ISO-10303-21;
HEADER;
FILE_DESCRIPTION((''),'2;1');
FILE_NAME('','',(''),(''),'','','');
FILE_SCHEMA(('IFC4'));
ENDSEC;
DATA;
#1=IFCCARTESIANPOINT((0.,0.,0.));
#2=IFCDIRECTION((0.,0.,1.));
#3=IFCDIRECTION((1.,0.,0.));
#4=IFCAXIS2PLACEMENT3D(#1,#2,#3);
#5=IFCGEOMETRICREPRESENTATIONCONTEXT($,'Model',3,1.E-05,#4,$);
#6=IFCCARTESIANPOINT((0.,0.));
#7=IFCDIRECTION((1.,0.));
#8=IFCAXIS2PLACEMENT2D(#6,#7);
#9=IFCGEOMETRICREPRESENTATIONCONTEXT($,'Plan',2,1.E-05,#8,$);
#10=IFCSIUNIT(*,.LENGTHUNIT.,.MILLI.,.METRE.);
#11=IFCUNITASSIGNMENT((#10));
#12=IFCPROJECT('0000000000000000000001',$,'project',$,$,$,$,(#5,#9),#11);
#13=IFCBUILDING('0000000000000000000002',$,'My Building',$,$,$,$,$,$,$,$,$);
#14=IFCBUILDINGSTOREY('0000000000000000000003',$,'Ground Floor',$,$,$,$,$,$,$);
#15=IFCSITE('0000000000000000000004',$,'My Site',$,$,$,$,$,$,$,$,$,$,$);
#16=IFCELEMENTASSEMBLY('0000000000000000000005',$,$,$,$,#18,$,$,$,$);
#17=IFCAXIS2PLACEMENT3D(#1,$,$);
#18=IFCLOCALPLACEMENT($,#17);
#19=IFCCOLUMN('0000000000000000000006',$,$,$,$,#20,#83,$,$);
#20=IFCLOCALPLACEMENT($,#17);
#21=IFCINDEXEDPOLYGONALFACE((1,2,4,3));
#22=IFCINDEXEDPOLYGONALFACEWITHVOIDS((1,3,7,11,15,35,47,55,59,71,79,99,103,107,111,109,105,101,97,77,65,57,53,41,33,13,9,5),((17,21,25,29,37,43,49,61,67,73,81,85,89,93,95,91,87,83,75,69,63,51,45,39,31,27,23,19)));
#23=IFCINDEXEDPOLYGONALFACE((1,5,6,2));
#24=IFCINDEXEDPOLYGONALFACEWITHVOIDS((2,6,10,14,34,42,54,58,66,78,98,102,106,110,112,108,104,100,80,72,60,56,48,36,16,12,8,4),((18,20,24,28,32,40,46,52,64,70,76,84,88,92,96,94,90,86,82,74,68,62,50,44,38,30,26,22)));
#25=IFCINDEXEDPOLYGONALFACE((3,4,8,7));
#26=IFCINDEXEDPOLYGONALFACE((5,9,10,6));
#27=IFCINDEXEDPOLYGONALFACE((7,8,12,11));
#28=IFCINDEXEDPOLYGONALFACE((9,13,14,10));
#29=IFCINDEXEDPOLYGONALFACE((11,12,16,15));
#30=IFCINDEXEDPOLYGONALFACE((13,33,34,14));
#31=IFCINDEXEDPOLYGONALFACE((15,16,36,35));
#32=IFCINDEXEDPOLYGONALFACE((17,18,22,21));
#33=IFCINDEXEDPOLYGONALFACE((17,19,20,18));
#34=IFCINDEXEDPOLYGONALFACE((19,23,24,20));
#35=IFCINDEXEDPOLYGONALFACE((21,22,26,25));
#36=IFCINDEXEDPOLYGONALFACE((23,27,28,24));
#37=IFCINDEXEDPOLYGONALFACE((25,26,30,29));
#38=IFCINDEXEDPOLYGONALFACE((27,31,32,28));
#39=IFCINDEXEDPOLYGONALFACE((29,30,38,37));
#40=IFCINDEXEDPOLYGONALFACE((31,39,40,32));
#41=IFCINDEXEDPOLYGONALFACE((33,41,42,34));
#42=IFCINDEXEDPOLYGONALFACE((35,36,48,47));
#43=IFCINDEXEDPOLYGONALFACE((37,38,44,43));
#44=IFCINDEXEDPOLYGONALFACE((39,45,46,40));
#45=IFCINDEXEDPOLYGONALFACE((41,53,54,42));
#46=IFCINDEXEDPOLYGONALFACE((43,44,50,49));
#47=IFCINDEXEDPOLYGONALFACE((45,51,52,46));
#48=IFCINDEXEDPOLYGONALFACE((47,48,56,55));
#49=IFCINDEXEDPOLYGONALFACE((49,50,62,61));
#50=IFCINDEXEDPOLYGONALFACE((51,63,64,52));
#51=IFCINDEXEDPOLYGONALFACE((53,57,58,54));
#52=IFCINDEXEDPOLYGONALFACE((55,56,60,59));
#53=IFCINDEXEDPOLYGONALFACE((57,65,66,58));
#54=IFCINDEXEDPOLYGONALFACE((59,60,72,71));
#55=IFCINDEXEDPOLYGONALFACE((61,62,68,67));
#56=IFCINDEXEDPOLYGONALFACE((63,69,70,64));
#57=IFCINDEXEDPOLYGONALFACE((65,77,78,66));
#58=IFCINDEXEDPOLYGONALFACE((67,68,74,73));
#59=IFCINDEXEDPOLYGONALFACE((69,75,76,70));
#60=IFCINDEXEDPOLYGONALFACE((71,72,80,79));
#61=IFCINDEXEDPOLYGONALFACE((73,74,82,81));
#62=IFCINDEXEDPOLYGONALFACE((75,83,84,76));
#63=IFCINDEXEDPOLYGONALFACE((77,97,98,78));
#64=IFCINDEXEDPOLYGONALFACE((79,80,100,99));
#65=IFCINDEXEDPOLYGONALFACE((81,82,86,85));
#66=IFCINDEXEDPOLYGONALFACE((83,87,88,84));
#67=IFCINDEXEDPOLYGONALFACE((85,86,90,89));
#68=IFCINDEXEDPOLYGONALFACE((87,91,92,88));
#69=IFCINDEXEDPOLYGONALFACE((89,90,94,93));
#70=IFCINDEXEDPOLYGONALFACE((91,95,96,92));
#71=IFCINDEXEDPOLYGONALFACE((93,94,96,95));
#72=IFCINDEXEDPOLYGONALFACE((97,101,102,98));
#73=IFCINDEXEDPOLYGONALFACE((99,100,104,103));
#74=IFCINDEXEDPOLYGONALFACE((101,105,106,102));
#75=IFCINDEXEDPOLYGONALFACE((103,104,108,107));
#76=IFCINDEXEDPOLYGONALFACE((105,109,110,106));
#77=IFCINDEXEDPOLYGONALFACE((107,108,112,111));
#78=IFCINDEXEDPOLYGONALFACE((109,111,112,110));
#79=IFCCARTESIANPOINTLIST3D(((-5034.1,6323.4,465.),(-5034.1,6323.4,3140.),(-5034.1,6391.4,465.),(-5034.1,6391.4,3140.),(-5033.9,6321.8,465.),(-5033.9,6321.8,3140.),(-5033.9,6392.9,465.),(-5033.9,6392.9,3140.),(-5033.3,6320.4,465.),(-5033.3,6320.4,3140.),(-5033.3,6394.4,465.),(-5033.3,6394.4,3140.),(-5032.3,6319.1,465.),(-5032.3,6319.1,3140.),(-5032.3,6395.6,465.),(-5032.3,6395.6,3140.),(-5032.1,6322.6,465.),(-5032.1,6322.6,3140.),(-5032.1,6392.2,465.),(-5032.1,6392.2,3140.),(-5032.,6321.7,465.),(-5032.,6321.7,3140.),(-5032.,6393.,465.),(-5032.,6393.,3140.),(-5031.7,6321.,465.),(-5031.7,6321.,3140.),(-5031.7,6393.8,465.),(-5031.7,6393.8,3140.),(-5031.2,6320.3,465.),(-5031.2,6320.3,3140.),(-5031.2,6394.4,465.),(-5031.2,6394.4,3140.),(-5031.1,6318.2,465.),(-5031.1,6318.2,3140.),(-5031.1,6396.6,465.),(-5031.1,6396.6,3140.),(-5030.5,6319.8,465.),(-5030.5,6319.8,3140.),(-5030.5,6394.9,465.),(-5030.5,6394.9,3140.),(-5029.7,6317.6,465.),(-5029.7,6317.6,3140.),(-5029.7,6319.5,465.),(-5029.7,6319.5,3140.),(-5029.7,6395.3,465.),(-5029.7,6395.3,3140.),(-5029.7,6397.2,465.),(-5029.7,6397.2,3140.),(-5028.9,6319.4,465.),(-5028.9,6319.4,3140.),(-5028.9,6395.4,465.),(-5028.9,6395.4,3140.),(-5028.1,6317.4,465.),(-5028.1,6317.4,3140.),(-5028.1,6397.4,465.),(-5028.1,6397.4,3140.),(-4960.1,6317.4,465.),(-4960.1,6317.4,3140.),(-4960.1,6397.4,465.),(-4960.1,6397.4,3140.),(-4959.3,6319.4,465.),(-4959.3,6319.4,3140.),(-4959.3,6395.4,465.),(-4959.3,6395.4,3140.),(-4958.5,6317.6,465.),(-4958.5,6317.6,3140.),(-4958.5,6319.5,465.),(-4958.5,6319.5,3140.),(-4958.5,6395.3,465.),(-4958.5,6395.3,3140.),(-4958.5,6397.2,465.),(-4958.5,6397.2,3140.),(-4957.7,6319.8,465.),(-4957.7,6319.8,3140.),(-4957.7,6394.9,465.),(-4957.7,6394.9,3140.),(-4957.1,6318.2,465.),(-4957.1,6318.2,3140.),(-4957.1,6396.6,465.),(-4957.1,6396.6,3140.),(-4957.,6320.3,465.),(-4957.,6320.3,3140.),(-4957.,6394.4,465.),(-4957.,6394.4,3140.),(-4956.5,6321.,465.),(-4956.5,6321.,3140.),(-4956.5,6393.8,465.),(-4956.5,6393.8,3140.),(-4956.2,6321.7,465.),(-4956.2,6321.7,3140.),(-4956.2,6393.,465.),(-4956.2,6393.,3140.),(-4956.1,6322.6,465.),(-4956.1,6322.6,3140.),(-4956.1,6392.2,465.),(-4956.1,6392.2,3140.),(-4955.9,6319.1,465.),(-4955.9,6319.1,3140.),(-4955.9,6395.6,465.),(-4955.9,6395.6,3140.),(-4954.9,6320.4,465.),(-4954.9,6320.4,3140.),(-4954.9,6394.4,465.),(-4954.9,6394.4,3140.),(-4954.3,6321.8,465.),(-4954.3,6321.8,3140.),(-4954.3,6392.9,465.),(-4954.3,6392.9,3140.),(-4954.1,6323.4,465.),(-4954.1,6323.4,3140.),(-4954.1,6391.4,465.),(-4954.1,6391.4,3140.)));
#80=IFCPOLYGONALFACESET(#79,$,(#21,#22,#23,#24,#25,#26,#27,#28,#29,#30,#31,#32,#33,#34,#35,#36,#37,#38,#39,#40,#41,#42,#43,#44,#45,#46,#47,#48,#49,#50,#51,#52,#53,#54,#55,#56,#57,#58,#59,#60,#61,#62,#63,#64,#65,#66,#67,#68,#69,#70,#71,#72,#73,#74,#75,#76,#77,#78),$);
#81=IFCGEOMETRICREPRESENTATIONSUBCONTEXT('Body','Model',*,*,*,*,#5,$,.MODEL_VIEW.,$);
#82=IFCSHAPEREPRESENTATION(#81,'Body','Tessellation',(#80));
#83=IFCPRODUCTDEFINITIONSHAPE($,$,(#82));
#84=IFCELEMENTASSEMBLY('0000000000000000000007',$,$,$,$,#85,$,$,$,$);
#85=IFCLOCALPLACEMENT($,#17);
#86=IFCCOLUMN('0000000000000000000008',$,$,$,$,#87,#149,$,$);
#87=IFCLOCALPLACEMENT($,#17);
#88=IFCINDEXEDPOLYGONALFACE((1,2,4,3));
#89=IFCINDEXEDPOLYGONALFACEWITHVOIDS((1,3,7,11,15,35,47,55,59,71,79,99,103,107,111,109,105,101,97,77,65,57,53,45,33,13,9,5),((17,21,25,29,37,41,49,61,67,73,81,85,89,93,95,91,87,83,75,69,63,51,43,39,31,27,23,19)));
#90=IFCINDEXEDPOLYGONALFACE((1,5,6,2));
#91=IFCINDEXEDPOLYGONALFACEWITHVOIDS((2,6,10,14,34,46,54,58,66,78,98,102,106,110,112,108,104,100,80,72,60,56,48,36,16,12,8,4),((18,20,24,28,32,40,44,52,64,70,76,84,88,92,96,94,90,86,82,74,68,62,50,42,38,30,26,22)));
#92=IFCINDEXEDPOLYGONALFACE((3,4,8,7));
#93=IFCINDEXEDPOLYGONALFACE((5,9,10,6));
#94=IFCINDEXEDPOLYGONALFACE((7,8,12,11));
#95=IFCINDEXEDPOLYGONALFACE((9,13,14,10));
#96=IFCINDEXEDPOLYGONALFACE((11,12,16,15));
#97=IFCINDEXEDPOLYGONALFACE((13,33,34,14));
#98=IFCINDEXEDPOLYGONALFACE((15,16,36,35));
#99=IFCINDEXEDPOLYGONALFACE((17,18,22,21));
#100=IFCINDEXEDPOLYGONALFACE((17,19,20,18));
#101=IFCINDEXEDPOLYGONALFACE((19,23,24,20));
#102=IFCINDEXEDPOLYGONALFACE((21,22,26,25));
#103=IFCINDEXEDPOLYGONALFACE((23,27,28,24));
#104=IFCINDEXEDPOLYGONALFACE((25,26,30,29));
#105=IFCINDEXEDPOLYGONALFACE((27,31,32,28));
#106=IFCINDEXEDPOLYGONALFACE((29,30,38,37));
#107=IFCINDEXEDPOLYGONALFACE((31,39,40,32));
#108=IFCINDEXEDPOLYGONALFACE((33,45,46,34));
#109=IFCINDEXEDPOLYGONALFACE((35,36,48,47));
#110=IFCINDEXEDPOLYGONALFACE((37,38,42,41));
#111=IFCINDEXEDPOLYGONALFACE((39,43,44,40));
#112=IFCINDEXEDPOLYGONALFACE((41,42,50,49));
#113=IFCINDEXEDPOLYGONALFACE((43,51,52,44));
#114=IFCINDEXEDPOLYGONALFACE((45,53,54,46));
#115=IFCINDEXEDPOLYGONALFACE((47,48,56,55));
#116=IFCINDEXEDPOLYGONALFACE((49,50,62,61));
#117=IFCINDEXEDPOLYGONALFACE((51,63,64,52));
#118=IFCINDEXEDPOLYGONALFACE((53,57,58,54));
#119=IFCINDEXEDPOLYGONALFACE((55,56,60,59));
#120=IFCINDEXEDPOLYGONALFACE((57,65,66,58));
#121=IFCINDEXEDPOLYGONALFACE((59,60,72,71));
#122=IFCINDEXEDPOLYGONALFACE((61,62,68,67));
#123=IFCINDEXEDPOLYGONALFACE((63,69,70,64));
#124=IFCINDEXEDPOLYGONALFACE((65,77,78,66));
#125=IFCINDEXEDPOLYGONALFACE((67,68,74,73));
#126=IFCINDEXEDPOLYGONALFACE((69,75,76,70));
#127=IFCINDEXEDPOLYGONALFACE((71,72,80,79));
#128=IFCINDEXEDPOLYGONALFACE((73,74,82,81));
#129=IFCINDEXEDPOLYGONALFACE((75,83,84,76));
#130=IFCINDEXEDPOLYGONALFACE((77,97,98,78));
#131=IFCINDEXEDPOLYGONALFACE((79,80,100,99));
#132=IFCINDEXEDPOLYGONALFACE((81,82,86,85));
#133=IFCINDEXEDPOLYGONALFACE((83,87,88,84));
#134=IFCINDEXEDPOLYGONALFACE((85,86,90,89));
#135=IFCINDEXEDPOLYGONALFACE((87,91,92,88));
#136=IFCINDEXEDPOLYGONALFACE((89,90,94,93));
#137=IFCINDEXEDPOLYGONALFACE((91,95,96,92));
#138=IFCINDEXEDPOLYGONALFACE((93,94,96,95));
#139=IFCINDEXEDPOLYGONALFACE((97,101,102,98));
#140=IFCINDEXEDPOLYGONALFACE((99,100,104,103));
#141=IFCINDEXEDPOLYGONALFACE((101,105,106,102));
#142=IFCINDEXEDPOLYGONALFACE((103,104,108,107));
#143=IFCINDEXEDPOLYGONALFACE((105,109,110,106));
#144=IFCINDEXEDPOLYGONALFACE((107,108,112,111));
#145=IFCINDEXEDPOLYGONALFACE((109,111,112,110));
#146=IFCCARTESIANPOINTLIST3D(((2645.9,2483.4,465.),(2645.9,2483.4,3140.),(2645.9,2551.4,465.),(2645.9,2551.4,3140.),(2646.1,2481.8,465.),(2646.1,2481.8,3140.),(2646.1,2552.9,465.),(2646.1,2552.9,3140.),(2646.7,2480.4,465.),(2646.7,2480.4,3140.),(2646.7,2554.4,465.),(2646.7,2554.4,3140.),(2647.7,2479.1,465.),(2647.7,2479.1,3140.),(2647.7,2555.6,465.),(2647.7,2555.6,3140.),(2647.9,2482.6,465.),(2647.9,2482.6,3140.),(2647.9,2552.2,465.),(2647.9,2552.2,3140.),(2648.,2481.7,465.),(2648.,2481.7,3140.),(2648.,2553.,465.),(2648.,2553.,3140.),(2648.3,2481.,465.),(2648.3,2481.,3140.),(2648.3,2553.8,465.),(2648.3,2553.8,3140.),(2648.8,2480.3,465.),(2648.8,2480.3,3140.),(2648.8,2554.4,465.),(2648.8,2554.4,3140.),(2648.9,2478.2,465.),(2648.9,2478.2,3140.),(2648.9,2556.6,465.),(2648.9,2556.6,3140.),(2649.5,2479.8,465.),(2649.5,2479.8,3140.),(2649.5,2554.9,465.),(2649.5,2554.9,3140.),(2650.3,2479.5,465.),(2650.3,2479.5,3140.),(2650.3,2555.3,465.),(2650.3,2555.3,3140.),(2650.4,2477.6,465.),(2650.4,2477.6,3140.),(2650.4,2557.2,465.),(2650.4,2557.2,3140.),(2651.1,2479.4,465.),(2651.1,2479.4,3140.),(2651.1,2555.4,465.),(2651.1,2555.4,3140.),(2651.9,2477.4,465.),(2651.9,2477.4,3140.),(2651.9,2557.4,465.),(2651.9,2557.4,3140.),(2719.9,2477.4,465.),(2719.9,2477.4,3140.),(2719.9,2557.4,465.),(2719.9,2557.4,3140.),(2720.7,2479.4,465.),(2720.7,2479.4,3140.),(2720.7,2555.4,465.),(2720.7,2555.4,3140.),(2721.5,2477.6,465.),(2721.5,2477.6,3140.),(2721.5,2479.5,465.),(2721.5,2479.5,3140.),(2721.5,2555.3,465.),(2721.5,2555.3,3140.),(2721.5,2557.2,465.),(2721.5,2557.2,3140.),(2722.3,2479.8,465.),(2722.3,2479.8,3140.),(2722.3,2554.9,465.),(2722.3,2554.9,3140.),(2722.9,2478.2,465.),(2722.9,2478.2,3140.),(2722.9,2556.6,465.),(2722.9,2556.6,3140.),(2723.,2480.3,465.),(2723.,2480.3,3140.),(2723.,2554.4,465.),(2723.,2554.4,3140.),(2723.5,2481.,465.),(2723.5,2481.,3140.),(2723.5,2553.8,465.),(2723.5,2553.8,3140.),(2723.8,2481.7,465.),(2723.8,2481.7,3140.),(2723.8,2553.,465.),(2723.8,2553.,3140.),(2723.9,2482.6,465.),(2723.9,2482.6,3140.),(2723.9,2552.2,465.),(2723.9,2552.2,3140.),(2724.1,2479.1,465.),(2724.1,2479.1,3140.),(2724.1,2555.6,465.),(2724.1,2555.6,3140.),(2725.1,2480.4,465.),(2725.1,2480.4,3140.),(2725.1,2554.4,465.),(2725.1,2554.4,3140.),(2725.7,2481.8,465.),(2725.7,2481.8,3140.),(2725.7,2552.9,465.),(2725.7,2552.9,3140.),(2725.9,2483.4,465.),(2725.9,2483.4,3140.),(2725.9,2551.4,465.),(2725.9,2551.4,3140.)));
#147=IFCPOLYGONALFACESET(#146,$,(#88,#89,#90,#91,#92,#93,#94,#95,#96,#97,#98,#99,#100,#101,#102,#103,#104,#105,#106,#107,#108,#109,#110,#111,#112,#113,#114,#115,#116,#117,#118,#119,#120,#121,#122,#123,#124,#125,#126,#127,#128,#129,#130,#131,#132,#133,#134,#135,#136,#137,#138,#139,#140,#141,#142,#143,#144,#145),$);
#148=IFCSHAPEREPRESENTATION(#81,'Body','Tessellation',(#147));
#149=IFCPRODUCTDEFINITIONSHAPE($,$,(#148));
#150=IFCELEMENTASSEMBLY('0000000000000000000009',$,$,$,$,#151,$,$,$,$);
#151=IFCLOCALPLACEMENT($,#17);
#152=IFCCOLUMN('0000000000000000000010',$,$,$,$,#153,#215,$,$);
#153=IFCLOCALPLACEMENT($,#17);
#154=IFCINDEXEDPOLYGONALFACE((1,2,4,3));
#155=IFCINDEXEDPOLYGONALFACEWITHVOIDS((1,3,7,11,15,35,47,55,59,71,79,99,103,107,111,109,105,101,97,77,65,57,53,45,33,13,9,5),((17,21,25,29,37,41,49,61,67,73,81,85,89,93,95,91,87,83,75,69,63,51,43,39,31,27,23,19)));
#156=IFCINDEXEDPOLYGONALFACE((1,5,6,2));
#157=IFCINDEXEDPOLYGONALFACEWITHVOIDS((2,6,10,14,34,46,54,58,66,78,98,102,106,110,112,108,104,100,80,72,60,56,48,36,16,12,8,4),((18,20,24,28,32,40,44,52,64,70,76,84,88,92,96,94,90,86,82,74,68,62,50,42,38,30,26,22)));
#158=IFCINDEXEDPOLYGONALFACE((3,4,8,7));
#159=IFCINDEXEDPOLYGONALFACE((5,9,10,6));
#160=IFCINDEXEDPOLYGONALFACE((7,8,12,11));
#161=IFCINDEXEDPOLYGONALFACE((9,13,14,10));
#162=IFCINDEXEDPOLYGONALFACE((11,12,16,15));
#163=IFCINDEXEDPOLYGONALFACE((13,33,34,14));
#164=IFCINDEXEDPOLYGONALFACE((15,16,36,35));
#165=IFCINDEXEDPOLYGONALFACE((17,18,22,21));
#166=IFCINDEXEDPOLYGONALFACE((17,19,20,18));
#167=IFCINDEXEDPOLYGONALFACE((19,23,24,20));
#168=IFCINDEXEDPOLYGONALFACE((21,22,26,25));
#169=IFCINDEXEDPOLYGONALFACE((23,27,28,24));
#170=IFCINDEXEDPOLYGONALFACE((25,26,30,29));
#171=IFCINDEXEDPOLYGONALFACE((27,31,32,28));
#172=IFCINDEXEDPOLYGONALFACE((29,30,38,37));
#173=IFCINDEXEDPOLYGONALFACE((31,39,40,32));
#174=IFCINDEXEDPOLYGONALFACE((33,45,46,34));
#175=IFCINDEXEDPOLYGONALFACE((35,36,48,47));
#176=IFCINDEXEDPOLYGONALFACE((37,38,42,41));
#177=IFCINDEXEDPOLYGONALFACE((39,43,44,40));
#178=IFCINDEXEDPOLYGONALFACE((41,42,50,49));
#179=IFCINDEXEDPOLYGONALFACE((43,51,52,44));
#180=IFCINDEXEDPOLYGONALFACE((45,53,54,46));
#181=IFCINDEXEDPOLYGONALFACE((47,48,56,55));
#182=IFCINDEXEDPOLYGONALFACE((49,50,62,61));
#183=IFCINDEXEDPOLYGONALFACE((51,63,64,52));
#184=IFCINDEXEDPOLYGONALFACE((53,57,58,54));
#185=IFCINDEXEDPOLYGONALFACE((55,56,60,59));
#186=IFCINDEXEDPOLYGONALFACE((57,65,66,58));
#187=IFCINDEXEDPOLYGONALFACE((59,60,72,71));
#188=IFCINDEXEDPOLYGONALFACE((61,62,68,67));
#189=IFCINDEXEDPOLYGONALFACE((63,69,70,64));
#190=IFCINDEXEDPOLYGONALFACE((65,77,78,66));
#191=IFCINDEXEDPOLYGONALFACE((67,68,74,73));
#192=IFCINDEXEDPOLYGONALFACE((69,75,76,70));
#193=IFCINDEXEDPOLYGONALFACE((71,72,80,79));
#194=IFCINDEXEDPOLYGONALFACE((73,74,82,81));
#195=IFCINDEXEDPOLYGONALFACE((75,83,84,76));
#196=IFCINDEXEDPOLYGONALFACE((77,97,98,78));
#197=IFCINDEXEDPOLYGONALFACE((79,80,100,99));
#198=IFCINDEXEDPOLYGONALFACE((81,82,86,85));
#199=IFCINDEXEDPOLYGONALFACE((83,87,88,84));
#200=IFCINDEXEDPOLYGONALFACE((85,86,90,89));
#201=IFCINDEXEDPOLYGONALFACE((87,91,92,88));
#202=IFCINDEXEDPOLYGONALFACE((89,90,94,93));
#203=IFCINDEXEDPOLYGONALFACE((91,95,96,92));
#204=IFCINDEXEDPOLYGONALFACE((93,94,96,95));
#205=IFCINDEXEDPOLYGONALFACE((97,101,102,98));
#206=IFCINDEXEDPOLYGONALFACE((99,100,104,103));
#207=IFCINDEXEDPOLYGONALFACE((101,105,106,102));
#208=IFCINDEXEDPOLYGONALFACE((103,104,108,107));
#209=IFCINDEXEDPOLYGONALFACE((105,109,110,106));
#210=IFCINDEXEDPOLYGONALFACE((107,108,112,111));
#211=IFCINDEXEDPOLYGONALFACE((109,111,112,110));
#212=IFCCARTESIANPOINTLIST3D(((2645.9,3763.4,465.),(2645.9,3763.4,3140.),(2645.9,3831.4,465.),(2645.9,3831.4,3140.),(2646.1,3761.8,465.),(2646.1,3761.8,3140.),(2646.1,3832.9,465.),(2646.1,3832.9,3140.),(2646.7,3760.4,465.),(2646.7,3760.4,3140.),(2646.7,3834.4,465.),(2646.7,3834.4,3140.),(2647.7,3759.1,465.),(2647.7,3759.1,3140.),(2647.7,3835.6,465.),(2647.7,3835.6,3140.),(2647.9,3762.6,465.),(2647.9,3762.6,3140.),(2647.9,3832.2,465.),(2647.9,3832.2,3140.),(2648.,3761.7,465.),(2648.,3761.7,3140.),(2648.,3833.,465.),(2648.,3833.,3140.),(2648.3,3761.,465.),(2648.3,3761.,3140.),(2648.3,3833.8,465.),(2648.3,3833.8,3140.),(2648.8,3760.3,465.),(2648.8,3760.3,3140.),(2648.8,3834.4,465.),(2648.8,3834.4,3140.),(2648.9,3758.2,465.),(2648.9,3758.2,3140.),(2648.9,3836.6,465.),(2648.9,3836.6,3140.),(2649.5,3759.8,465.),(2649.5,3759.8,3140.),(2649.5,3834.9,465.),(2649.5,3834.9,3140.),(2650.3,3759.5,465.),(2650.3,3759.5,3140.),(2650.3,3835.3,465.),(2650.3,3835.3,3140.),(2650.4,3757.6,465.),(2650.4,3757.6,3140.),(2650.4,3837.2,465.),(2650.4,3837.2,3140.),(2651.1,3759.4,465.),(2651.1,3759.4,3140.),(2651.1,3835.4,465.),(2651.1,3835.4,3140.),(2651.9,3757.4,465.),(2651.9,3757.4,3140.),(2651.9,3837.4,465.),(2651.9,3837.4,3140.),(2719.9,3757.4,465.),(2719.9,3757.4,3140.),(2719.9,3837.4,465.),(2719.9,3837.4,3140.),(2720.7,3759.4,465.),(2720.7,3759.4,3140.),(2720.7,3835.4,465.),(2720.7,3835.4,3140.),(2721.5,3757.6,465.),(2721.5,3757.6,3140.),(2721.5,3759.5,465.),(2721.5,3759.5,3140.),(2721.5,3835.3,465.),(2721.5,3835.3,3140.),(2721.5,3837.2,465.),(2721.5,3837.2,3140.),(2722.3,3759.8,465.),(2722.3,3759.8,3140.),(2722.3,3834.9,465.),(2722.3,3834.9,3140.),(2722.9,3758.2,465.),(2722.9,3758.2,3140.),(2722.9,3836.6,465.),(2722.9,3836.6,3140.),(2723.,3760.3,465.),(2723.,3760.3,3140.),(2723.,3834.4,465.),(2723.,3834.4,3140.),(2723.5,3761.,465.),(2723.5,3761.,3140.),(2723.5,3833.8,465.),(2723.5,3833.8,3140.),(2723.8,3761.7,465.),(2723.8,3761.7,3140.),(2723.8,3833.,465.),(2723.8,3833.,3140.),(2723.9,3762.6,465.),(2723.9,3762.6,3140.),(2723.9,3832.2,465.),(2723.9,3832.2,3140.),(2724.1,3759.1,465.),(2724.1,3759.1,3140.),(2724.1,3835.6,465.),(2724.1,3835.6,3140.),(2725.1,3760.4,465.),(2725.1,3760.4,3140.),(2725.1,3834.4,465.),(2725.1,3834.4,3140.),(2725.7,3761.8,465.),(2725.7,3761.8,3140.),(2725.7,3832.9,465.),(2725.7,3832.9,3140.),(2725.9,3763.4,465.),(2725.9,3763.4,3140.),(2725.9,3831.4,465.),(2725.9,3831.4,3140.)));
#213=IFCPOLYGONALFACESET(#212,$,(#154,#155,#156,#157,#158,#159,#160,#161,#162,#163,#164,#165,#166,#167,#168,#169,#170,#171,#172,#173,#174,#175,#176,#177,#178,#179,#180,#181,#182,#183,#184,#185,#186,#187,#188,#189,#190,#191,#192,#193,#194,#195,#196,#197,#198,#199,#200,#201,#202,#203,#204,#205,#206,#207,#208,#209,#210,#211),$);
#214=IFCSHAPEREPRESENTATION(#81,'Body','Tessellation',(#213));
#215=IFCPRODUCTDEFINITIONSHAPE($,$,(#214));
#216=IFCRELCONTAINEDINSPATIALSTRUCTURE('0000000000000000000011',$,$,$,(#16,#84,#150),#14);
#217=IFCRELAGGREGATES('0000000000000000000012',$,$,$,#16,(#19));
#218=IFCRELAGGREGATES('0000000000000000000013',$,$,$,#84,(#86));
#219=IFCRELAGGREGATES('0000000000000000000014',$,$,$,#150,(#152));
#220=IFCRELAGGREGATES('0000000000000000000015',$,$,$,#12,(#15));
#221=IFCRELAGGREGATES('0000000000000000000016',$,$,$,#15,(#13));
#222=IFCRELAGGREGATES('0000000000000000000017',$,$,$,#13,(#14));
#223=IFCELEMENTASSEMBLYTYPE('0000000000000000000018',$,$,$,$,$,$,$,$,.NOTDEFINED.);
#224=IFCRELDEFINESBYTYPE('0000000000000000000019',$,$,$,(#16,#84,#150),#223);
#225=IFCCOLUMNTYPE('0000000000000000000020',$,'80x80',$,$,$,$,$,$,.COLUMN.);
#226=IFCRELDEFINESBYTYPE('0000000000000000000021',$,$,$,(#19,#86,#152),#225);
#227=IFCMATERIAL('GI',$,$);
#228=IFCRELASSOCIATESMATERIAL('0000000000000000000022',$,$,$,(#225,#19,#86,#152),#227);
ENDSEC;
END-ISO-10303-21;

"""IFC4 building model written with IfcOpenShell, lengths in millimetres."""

from ifc_helpers import new_model, si_unit, frame, origin_with_axes, origin_2d_with_axis, place, context, subcontext, project, spatial, hollow_rectangle, extrude, material, material_profile, profile_set, profile_usage, type_object, element, aggregate, save


model = new_model("IFC4")

# Units and contexts
model_context = context("Model", 3, precision=1e-05, world=origin_with_axes())
plan_context = context("Plan", 2, precision=1e-05, world=origin_2d_with_axis())
body_context = subcontext(model_context, "Body", "Model", "MODEL_VIEW")
ifc_project = project(units=[si_unit("LENGTHUNIT", "METRE", prefix="MILLI")], contexts=[model_context, plan_context])

# Site, building, storey
site = spatial("IfcSite", under=ifc_project, Name="My Site")
building = spatial("IfcBuilding", under=site, Name="My Building")
storey = spatial("IfcBuildingStorey", under=building, Name="Ground Floor")

# Element assemblies, columns
element_assembly_type_1 = type_object("IfcElementAssemblyType", PredefinedType="NOTDEFINED")
ifc_material = material(Name="GI")
ifc_material_profile_1 = material_profile(ifc_material, hollow_rectangle(XDim=80.0, YDim=80.0, WallThickness=2.0, InnerFilletRadius=3.2, OuterFilletRadius=6.0))
ifc_profile_set_1 = profile_set([ifc_material_profile_1], Name="80x80 GI Rectangular Hollow")
column_type = type_object("IfcColumnType", Name="80x80", PredefinedType="COLUMN", material=ifc_profile_set_1)
assembly_1_placement = place(None, frame((-4994.1, 6357.4, 465.0), z_axis=(0.0, 0.0, 1.0), x_axis=(1.0, 0.0, 0.0)))
assembly_1 = element("IfcElementAssembly", 1, at=assembly_1_placement, inside=storey, type_object=element_assembly_type_1)
ifc_profile_usage_1 = profile_usage(ifc_profile_set_1)
column_1_placement = place(assembly_1_placement, origin_with_axes())
column_1 = element("IfcColumn", 2, at=column_1_placement, type_object=column_type, material=ifc_profile_usage_1, context=body_context, shape_type="SweptSolid", body=[
    extrude(hollow_rectangle(XDim=80.0, YDim=80.0, WallThickness=2.0, InnerFilletRadius=3.2, OuterFilletRadius=6.0), origin_with_axes(), (0.0, 0.0, 1.0), 2675.0),
])
aggregate(assembly_1, [column_1])
assembly_2_placement = place(None, frame((2685.9, 2517.4, 465.0), z_axis=(0.0, 0.0, 1.0), x_axis=(1.0, 0.0, 0.0)))
assembly_2 = element("IfcElementAssembly", 3, at=assembly_2_placement, inside=storey, type_object=element_assembly_type_1)
ifc_profile_usage_2 = profile_usage(ifc_profile_set_1)
column_2_placement = place(assembly_2_placement, origin_with_axes())
column_2 = element("IfcColumn", 4, at=column_2_placement, type_object=column_type, material=ifc_profile_usage_2, context=body_context, shape_type="SweptSolid", body=[
    extrude(hollow_rectangle(XDim=80.0, YDim=80.0, WallThickness=2.0, InnerFilletRadius=3.2, OuterFilletRadius=6.0), origin_with_axes(), (0.0, 0.0, 1.0), 2675.0),
])
aggregate(assembly_2, [column_2])
assembly_3_placement = place(None, frame((2685.9, 3797.4, 465.0), z_axis=(0.0, 0.0, 1.0), x_axis=(1.0, 0.0, 0.0)))
assembly_3 = element("IfcElementAssembly", 5, at=assembly_3_placement, inside=storey, type_object=element_assembly_type_1)
ifc_profile_usage_3 = profile_usage(ifc_profile_set_1)
column_3_placement = place(assembly_3_placement, origin_with_axes())
column_3 = element("IfcColumn", 6, at=column_3_placement, type_object=column_type, material=ifc_profile_usage_3, context=body_context, shape_type="SweptSolid", body=[
    extrude(hollow_rectangle(XDim=80.0, YDim=80.0, WallThickness=2.0, InnerFilletRadius=3.2, OuterFilletRadius=6.0), origin_with_axes(), (0.0, 0.0, 1.0), 2675.0),
])
aggregate(assembly_3, [column_3])

save(model, "model.ifc")
